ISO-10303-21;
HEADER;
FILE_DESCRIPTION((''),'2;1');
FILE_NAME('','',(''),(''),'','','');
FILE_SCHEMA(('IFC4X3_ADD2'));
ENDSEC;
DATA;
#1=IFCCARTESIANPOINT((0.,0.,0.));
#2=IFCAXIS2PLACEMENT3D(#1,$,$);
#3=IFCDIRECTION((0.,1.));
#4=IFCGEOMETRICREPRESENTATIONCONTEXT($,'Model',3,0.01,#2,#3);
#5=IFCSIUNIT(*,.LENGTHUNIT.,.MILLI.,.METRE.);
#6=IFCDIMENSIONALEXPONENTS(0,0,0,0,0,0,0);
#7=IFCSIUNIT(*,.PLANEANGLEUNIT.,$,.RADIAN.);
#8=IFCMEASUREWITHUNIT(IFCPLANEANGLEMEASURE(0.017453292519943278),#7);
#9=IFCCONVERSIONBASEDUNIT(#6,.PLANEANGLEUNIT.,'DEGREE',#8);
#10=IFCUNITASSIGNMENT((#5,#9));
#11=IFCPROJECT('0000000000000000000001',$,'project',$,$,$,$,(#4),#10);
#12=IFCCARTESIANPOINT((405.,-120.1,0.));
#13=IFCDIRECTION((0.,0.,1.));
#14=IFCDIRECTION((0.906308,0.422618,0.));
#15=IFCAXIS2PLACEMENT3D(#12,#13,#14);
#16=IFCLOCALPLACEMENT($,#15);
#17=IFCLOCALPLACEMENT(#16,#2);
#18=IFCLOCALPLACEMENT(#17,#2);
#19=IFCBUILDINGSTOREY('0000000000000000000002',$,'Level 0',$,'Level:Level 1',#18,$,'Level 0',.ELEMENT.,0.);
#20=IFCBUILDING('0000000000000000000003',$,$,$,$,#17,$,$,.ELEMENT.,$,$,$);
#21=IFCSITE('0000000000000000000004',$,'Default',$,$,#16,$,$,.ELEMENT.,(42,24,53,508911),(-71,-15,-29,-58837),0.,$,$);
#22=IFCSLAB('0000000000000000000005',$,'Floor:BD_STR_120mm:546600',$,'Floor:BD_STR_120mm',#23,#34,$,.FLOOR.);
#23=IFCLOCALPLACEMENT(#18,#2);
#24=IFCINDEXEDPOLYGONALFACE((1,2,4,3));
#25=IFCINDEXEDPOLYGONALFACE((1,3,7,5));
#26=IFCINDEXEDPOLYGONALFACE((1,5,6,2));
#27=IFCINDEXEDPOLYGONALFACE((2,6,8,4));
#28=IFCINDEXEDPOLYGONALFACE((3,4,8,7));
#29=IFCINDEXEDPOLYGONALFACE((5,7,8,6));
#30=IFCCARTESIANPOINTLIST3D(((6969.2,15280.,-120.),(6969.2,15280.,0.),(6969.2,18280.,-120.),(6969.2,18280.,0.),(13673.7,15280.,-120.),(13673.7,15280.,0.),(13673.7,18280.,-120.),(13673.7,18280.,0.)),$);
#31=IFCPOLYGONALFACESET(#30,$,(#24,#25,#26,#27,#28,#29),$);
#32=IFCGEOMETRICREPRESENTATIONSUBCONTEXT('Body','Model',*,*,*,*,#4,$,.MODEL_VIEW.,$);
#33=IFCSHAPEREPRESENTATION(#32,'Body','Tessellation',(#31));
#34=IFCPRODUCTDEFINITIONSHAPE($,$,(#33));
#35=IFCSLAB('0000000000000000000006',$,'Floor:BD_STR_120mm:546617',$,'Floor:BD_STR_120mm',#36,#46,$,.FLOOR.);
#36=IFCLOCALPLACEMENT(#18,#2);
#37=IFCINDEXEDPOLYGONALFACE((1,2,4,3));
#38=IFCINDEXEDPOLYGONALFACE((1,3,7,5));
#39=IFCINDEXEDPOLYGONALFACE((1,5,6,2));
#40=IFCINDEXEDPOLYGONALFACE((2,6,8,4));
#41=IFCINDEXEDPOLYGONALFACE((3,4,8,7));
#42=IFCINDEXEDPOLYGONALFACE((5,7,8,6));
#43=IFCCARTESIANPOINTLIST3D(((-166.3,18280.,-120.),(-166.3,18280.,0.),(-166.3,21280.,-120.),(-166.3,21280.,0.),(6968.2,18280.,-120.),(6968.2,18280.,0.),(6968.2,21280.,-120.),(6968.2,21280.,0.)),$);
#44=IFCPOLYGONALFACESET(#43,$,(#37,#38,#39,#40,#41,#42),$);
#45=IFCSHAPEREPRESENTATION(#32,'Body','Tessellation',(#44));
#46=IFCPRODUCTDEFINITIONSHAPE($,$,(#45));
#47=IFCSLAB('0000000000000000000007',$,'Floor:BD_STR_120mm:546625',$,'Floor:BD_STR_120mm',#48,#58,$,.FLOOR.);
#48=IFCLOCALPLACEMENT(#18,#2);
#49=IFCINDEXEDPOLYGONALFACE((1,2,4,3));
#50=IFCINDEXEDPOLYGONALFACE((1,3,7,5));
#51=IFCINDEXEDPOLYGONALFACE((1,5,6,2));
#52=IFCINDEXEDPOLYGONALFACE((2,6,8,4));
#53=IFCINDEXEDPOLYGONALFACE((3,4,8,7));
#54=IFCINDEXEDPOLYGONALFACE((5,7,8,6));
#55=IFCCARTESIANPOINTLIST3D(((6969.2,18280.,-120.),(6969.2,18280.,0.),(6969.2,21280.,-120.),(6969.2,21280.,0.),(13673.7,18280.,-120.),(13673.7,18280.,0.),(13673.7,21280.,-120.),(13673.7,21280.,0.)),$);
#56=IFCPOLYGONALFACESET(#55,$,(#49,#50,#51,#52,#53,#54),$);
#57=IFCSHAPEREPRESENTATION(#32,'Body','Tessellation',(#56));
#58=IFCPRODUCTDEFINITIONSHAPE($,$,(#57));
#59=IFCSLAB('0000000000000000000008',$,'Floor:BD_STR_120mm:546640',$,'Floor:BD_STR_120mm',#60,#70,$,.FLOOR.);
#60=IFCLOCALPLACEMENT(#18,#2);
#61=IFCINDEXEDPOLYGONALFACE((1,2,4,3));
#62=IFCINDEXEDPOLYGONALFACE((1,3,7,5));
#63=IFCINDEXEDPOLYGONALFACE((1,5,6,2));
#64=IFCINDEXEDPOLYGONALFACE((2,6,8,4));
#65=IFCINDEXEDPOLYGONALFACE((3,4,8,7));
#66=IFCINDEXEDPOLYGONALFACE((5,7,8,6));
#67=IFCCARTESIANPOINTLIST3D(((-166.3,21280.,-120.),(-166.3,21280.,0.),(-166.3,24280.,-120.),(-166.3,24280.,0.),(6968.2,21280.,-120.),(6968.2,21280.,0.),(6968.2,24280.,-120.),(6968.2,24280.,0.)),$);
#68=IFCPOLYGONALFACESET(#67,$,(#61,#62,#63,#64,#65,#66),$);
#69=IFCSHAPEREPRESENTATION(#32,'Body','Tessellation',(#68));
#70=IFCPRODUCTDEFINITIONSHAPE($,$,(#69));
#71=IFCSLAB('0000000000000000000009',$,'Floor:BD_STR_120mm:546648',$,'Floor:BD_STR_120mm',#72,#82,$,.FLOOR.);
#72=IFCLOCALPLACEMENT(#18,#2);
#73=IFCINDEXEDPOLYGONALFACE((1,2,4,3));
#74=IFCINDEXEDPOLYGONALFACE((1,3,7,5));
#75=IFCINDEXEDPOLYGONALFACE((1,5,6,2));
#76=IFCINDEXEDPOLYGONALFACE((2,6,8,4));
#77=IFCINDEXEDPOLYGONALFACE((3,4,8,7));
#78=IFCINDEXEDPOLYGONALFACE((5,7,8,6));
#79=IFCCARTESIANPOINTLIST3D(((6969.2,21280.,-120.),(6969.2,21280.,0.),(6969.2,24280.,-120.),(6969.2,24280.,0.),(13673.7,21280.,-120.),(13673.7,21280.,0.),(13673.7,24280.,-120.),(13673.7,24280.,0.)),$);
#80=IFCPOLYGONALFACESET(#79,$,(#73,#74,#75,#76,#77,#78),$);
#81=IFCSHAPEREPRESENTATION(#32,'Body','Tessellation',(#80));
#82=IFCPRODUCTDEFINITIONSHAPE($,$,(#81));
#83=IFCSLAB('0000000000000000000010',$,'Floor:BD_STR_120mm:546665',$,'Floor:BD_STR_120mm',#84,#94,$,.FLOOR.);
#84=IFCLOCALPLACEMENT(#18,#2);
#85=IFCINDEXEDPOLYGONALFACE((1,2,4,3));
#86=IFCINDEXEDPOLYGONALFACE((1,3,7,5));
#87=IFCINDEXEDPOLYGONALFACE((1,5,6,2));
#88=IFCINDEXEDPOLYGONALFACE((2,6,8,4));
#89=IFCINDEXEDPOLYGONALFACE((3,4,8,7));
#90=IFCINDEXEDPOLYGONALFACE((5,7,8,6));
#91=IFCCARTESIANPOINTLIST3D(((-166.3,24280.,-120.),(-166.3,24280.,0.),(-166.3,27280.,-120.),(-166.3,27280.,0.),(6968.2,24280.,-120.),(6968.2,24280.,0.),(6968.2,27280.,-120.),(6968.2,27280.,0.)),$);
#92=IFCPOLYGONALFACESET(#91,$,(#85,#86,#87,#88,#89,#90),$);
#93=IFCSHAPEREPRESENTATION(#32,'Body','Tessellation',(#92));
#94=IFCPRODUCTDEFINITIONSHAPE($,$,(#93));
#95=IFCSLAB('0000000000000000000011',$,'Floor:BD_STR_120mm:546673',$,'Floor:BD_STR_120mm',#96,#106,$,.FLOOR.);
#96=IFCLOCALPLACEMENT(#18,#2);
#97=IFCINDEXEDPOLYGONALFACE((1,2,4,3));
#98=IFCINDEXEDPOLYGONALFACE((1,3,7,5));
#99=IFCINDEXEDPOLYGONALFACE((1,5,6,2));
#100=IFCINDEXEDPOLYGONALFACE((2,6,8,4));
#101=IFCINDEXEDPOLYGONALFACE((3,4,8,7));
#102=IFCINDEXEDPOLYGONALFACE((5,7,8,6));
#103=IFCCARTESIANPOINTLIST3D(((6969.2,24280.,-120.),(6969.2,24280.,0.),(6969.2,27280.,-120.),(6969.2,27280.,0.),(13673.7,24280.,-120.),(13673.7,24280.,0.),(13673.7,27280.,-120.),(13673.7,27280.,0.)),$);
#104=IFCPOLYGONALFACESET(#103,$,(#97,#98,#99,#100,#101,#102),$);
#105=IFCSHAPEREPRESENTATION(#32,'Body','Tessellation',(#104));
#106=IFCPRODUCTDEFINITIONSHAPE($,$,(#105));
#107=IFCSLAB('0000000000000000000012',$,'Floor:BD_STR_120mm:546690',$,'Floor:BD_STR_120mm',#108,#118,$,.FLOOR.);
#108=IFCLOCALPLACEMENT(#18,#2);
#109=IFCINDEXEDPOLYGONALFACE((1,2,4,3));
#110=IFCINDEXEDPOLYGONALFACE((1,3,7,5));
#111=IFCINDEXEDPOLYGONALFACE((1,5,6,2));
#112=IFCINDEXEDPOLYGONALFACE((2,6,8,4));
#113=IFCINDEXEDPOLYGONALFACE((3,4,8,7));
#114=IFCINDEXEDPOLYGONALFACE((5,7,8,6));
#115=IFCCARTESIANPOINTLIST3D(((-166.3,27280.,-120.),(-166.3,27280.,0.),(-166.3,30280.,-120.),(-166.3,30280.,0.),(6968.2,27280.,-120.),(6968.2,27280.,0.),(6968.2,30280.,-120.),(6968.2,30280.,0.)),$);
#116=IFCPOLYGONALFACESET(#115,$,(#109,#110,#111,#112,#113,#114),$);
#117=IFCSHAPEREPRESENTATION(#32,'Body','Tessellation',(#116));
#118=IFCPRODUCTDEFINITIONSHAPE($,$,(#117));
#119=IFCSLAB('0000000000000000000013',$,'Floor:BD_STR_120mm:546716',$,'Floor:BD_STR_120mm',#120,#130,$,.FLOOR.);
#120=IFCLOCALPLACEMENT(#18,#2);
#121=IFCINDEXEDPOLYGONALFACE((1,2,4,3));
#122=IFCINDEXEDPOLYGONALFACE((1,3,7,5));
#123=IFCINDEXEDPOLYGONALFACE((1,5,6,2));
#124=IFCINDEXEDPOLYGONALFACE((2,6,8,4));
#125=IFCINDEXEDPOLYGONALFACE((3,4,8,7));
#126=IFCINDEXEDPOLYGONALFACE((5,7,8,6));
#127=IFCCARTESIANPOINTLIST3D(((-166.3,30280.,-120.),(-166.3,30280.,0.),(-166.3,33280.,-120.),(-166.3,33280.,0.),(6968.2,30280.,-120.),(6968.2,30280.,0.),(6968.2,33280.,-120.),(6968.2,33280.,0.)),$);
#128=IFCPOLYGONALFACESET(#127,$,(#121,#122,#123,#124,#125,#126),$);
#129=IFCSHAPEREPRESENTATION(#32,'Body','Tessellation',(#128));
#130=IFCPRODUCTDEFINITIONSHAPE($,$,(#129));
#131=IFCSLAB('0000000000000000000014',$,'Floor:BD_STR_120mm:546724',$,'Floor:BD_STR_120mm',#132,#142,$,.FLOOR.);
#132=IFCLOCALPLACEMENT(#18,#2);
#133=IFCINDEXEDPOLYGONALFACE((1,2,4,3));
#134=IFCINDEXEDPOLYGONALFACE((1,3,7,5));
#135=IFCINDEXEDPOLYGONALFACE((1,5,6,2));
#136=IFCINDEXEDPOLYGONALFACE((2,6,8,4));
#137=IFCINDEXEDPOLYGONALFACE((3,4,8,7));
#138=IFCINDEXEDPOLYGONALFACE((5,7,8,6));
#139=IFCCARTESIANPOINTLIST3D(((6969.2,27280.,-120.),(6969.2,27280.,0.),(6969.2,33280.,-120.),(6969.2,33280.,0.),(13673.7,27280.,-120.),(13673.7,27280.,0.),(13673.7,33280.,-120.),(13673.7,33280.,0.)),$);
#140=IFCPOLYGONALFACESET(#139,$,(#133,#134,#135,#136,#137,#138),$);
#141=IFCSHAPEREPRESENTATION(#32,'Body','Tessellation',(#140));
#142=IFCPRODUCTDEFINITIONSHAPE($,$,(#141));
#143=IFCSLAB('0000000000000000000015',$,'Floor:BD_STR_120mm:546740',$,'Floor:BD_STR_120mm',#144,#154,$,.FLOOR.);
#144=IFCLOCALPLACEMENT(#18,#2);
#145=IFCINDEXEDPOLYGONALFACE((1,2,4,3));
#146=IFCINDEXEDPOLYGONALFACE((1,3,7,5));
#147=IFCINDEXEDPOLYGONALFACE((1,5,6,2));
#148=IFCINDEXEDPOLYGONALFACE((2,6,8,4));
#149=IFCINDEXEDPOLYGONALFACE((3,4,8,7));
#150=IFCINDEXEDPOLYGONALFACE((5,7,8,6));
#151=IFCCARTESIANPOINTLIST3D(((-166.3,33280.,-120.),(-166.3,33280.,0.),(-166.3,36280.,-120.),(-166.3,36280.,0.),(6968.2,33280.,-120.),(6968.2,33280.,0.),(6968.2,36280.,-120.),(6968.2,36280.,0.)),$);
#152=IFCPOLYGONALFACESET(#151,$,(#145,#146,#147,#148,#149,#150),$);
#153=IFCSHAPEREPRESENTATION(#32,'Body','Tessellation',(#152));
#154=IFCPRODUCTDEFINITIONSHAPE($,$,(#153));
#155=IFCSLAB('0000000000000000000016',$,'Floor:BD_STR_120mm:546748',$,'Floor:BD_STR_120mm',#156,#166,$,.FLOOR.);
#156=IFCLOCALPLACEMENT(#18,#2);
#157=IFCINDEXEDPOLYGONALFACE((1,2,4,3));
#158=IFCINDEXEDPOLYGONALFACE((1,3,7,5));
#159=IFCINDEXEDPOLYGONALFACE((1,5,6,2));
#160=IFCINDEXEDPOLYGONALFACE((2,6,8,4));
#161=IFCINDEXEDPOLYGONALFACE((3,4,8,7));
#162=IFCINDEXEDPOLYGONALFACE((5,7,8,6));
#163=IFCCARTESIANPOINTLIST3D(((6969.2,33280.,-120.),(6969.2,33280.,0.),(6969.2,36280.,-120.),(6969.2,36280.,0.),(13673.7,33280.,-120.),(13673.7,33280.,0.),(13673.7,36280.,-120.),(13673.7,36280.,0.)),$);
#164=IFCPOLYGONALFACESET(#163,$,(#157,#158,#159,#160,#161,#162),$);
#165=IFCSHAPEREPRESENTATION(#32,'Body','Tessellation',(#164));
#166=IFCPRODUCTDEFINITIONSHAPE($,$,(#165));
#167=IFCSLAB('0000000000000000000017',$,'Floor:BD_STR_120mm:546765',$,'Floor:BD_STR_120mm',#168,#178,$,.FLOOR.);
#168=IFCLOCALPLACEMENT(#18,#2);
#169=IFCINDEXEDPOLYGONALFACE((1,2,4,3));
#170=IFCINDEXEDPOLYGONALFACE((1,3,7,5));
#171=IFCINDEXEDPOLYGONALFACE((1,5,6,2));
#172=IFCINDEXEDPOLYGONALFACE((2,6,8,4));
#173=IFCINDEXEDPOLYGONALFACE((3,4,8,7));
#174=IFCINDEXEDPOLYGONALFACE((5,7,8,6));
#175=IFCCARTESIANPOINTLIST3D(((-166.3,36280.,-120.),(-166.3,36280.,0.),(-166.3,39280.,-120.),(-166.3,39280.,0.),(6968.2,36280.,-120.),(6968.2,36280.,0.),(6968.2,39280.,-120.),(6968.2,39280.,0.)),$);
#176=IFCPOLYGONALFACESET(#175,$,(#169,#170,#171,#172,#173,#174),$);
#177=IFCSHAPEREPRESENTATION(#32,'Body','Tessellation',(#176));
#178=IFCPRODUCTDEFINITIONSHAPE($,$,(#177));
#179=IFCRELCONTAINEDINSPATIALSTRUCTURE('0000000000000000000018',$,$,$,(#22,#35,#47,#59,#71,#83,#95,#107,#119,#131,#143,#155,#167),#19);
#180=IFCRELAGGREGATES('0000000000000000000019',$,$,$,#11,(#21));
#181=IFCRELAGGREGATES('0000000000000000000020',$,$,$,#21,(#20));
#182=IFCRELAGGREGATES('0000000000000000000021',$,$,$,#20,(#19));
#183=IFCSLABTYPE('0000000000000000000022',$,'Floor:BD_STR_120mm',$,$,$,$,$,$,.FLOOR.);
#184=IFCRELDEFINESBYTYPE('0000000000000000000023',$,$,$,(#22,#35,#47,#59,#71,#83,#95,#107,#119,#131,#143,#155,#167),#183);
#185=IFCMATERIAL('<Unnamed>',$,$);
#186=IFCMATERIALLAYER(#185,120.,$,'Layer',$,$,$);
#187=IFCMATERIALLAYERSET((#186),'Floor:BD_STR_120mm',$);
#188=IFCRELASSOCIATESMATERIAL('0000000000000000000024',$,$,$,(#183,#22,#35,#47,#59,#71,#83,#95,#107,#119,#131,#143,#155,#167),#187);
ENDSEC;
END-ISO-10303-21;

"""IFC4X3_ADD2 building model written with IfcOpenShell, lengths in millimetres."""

from ifc_helpers import new_model, entity, si_unit, converted_unit, direction, frame, frame_2d, origin, place, context, subcontext, project, spatial, rectangle, extrude, material, layer, layer_set, layer_usage, type_object, element, save


model = new_model("IFC4X3_ADD2")

# Units and contexts
model_context = context("Model", 3, precision=0.01, world=origin(), true_north=direction((0.0, 1.0)))
body_context = subcontext(model_context, "Body", "Model", "MODEL_VIEW")
ifc_project = project(units=[si_unit("LENGTHUNIT", "METRE", prefix="MILLI"), converted_unit("PLANEANGLEUNIT", "DEGREE", entity("IfcPlaneAngleMeasure", 0.017453292519943278), si_unit("PLANEANGLEUNIT", "RADIAN"), dimensions=[0, 0, 0, 0, 0, 0, 0])], contexts=[model_context])

# Site, building, storey
site_placement = place(None, frame((405.0, -120.1, 0.0), z_axis=(0.0, 0.0, 1.0), x_axis=(0.906308, 0.422618, 0.0)))
site = spatial("IfcSite", under=ifc_project, at=site_placement, Name="Default", CompositionType="ELEMENT", RefLatitude=(42, 24, 53, 508911), RefLongitude=(-71, -15, -29, -58837), RefElevation=0.0)
building_placement = place(site_placement, origin())
building = spatial("IfcBuilding", under=site, at=building_placement, CompositionType="ELEMENT")
storey_placement = place(building_placement, origin())
storey = spatial("IfcBuildingStorey", under=building, at=storey_placement, Name="Level 0", ObjectType="Level:Level 1", LongName="Level 0", CompositionType="ELEMENT", Elevation=0.0)

# Slabs
ifc_material = material(Name="<Unnamed>")
ifc_layer = layer(ifc_material, 120.0, Name="Layer")
ifc_layer_set = layer_set([ifc_layer], Name="Floor:BD_STR_120mm")
ifc_layer_usage_1 = layer_usage(ifc_layer_set, "AXIS3", "POSITIVE", 0.0)
slab_type = type_object("IfcSlabType", Name="Floor:BD_STR_120mm", PredefinedType="FLOOR", material=ifc_layer_set)
slab_1_placement = place(storey_placement, origin())
element("IfcSlab", 1, at=slab_1_placement, inside=storey, type_object=slab_type, material=ifc_layer_usage_1, Name="Floor:BD_STR_120mm:546600", ObjectType="Floor:BD_STR_120mm", PredefinedType="FLOOR", context=body_context, shape_type="SweptSolid", body=[
    extrude(rectangle(XDim=3000.0, YDim=6704.5, at=frame_2d((0.0, 0.0), x_axis=(1.0, 0.0))), frame((10321.5, 16780.0, 0.0), z_axis=(0.0, 0.0, -1.0), x_axis=(0.0, 1.0, 0.0)), (0.0, 0.0, 1.0), 120.0),
])
ifc_layer_usage_2 = layer_usage(ifc_layer_set, "AXIS3", "POSITIVE", 0.0)
slab_2_placement = place(storey_placement, origin())
element("IfcSlab", 2, at=slab_2_placement, inside=storey, type_object=slab_type, material=ifc_layer_usage_2, Name="Floor:BD_STR_120mm:546617", ObjectType="Floor:BD_STR_120mm", PredefinedType="FLOOR", context=body_context, shape_type="SweptSolid", body=[
    extrude(rectangle(XDim=3000.0, YDim=7134.5, at=frame_2d((0.0, 0.0), x_axis=(1.0, 0.0))), frame((3401.0, 19780.0, 0.0), z_axis=(0.0, 0.0, -1.0), x_axis=(0.0, 1.0, 0.0)), (0.0, 0.0, 1.0), 120.0),
])
ifc_layer_usage_3 = layer_usage(ifc_layer_set, "AXIS3", "POSITIVE", 0.0)
slab_3_placement = place(storey_placement, origin())
element("IfcSlab", 3, at=slab_3_placement, inside=storey, type_object=slab_type, material=ifc_layer_usage_3, Name="Floor:BD_STR_120mm:546625", ObjectType="Floor:BD_STR_120mm", PredefinedType="FLOOR", context=body_context, shape_type="SweptSolid", body=[
    extrude(rectangle(XDim=3000.0, YDim=6704.5, at=frame_2d((0.0, 0.0), x_axis=(1.0, 0.0))), frame((10321.5, 19780.0, 0.0), z_axis=(0.0, 0.0, -1.0), x_axis=(0.0, 1.0, 0.0)), (0.0, 0.0, 1.0), 120.0),
])
ifc_layer_usage_4 = layer_usage(ifc_layer_set, "AXIS3", "POSITIVE", 0.0)
slab_4_placement = place(storey_placement, origin())
element("IfcSlab", 4, at=slab_4_placement, inside=storey, type_object=slab_type, material=ifc_layer_usage_4, Name="Floor:BD_STR_120mm:546640", ObjectType="Floor:BD_STR_120mm", PredefinedType="FLOOR", context=body_context, shape_type="SweptSolid", body=[
    extrude(rectangle(XDim=3000.0, YDim=7134.5, at=frame_2d((0.0, 0.0), x_axis=(1.0, 0.0))), frame((3401.0, 22780.0, 0.0), z_axis=(0.0, 0.0, -1.0), x_axis=(0.0, 1.0, 0.0)), (0.0, 0.0, 1.0), 120.0),
])
ifc_layer_usage_5 = layer_usage(ifc_layer_set, "AXIS3", "POSITIVE", 0.0)
slab_5_placement = place(storey_placement, origin())
element("IfcSlab", 5, at=slab_5_placement, inside=storey, type_object=slab_type, material=ifc_layer_usage_5, Name="Floor:BD_STR_120mm:546648", ObjectType="Floor:BD_STR_120mm", PredefinedType="FLOOR", context=body_context, shape_type="SweptSolid", body=[
    extrude(rectangle(XDim=3000.0, YDim=6704.5, at=frame_2d((0.0, 0.0), x_axis=(1.0, 0.0))), frame((10321.5, 22780.0, 0.0), z_axis=(0.0, 0.0, -1.0), x_axis=(0.0, 1.0, 0.0)), (0.0, 0.0, 1.0), 120.0),
])
ifc_layer_usage_6 = layer_usage(ifc_layer_set, "AXIS3", "POSITIVE", 0.0)
slab_6_placement = place(storey_placement, origin())
element("IfcSlab", 6, at=slab_6_placement, inside=storey, type_object=slab_type, material=ifc_layer_usage_6, Name="Floor:BD_STR_120mm:546665", ObjectType="Floor:BD_STR_120mm", PredefinedType="FLOOR", context=body_context, shape_type="SweptSolid", body=[
    extrude(rectangle(XDim=3000.0, YDim=7134.5, at=frame_2d((0.0, 0.0), x_axis=(1.0, 0.0))), frame((3401.0, 25780.0, 0.0), z_axis=(0.0, 0.0, -1.0), x_axis=(0.0, 1.0, 0.0)), (0.0, 0.0, 1.0), 120.0),
])
ifc_layer_usage_7 = layer_usage(ifc_layer_set, "AXIS3", "POSITIVE", 0.0)
slab_7_placement = place(storey_placement, origin())
element("IfcSlab", 7, at=slab_7_placement, inside=storey, type_object=slab_type, material=ifc_layer_usage_7, Name="Floor:BD_STR_120mm:546673", ObjectType="Floor:BD_STR_120mm", PredefinedType="FLOOR", context=body_context, shape_type="SweptSolid", body=[
    extrude(rectangle(XDim=3000.0, YDim=6704.5, at=frame_2d((0.0, 0.0), x_axis=(1.0, 0.0))), frame((10321.5, 25780.0, 0.0), z_axis=(0.0, 0.0, -1.0), x_axis=(0.0, 1.0, 0.0)), (0.0, 0.0, 1.0), 120.0),
])
ifc_layer_usage_8 = layer_usage(ifc_layer_set, "AXIS3", "POSITIVE", 0.0)
slab_8_placement = place(storey_placement, origin())
element("IfcSlab", 8, at=slab_8_placement, inside=storey, type_object=slab_type, material=ifc_layer_usage_8, Name="Floor:BD_STR_120mm:546690", ObjectType="Floor:BD_STR_120mm", PredefinedType="FLOOR", context=body_context, shape_type="SweptSolid", body=[
    extrude(rectangle(XDim=3000.0, YDim=7134.5, at=frame_2d((0.0, 0.0), x_axis=(1.0, 0.0))), frame((3401.0, 28780.0, 0.0), z_axis=(0.0, 0.0, -1.0), x_axis=(0.0, 1.0, 0.0)), (0.0, 0.0, 1.0), 120.0),
])
ifc_layer_usage_9 = layer_usage(ifc_layer_set, "AXIS3", "POSITIVE", 0.0)
slab_9_placement = place(storey_placement, origin())
element("IfcSlab", 9, at=slab_9_placement, inside=storey, type_object=slab_type, material=ifc_layer_usage_9, Name="Floor:BD_STR_120mm:546716", ObjectType="Floor:BD_STR_120mm", PredefinedType="FLOOR", context=body_context, shape_type="SweptSolid", body=[
    extrude(rectangle(XDim=3000.0, YDim=7134.5, at=frame_2d((0.0, 0.0), x_axis=(1.0, 0.0))), frame((3401.0, 31780.0, 0.0), z_axis=(0.0, 0.0, -1.0), x_axis=(0.0, 1.0, 0.0)), (0.0, 0.0, 1.0), 120.0),
])
ifc_layer_usage_10 = layer_usage(ifc_layer_set, "AXIS3", "POSITIVE", 0.0)
slab_10_placement = place(storey_placement, origin())
element("IfcSlab", 10, at=slab_10_placement, inside=storey, type_object=slab_type, material=ifc_layer_usage_10, Name="Floor:BD_STR_120mm:546724", ObjectType="Floor:BD_STR_120mm", PredefinedType="FLOOR", context=body_context, shape_type="SweptSolid", body=[
    extrude(rectangle(XDim=6000.0, YDim=6704.5, at=frame_2d((0.0, 0.0), x_axis=(1.0, 0.0))), frame((10321.5, 30280.0, 0.0), z_axis=(0.0, 0.0, -1.0), x_axis=(0.0, 1.0, 0.0)), (0.0, 0.0, 1.0), 120.0),
])
ifc_layer_usage_11 = layer_usage(ifc_layer_set, "AXIS3", "POSITIVE", 0.0)
slab_11_placement = place(storey_placement, origin())
element("IfcSlab", 11, at=slab_11_placement, inside=storey, type_object=slab_type, material=ifc_layer_usage_11, Name="Floor:BD_STR_120mm:546740", ObjectType="Floor:BD_STR_120mm", PredefinedType="FLOOR", context=body_context, shape_type="SweptSolid", body=[
    extrude(rectangle(XDim=3000.0, YDim=7134.5, at=frame_2d((0.0, 0.0), x_axis=(1.0, 0.0))), frame((3401.0, 34780.0, 0.0), z_axis=(0.0, 0.0, -1.0), x_axis=(0.0, 1.0, 0.0)), (0.0, 0.0, 1.0), 120.0),
])
ifc_layer_usage_12 = layer_usage(ifc_layer_set, "AXIS3", "POSITIVE", 0.0)
slab_12_placement = place(storey_placement, origin())
element("IfcSlab", 12, at=slab_12_placement, inside=storey, type_object=slab_type, material=ifc_layer_usage_12, Name="Floor:BD_STR_120mm:546748", ObjectType="Floor:BD_STR_120mm", PredefinedType="FLOOR", context=body_context, shape_type="SweptSolid", body=[
    extrude(rectangle(XDim=3000.0, YDim=6704.5, at=frame_2d((0.0, 0.0), x_axis=(1.0, 0.0))), frame((10321.5, 34780.0, 0.0), z_axis=(0.0, 0.0, -1.0), x_axis=(0.0, 1.0, 0.0)), (0.0, 0.0, 1.0), 120.0),
])
ifc_layer_usage_13 = layer_usage(ifc_layer_set, "AXIS3", "POSITIVE", 0.0)
slab_13_placement = place(storey_placement, origin())
element("IfcSlab", 13, at=slab_13_placement, inside=storey, type_object=slab_type, material=ifc_layer_usage_13, Name="Floor:BD_STR_120mm:546765", ObjectType="Floor:BD_STR_120mm", PredefinedType="FLOOR", context=body_context, shape_type="SweptSolid", body=[
    extrude(rectangle(XDim=3000.0, YDim=7134.5, at=frame_2d((0.0, 0.0), x_axis=(1.0, 0.0))), frame((3401.0, 37780.0, 0.0), z_axis=(0.0, 0.0, -1.0), x_axis=(0.0, 1.0, 0.0)), (0.0, 0.0, 1.0), 120.0),
])

save(model, "model.ifc")
